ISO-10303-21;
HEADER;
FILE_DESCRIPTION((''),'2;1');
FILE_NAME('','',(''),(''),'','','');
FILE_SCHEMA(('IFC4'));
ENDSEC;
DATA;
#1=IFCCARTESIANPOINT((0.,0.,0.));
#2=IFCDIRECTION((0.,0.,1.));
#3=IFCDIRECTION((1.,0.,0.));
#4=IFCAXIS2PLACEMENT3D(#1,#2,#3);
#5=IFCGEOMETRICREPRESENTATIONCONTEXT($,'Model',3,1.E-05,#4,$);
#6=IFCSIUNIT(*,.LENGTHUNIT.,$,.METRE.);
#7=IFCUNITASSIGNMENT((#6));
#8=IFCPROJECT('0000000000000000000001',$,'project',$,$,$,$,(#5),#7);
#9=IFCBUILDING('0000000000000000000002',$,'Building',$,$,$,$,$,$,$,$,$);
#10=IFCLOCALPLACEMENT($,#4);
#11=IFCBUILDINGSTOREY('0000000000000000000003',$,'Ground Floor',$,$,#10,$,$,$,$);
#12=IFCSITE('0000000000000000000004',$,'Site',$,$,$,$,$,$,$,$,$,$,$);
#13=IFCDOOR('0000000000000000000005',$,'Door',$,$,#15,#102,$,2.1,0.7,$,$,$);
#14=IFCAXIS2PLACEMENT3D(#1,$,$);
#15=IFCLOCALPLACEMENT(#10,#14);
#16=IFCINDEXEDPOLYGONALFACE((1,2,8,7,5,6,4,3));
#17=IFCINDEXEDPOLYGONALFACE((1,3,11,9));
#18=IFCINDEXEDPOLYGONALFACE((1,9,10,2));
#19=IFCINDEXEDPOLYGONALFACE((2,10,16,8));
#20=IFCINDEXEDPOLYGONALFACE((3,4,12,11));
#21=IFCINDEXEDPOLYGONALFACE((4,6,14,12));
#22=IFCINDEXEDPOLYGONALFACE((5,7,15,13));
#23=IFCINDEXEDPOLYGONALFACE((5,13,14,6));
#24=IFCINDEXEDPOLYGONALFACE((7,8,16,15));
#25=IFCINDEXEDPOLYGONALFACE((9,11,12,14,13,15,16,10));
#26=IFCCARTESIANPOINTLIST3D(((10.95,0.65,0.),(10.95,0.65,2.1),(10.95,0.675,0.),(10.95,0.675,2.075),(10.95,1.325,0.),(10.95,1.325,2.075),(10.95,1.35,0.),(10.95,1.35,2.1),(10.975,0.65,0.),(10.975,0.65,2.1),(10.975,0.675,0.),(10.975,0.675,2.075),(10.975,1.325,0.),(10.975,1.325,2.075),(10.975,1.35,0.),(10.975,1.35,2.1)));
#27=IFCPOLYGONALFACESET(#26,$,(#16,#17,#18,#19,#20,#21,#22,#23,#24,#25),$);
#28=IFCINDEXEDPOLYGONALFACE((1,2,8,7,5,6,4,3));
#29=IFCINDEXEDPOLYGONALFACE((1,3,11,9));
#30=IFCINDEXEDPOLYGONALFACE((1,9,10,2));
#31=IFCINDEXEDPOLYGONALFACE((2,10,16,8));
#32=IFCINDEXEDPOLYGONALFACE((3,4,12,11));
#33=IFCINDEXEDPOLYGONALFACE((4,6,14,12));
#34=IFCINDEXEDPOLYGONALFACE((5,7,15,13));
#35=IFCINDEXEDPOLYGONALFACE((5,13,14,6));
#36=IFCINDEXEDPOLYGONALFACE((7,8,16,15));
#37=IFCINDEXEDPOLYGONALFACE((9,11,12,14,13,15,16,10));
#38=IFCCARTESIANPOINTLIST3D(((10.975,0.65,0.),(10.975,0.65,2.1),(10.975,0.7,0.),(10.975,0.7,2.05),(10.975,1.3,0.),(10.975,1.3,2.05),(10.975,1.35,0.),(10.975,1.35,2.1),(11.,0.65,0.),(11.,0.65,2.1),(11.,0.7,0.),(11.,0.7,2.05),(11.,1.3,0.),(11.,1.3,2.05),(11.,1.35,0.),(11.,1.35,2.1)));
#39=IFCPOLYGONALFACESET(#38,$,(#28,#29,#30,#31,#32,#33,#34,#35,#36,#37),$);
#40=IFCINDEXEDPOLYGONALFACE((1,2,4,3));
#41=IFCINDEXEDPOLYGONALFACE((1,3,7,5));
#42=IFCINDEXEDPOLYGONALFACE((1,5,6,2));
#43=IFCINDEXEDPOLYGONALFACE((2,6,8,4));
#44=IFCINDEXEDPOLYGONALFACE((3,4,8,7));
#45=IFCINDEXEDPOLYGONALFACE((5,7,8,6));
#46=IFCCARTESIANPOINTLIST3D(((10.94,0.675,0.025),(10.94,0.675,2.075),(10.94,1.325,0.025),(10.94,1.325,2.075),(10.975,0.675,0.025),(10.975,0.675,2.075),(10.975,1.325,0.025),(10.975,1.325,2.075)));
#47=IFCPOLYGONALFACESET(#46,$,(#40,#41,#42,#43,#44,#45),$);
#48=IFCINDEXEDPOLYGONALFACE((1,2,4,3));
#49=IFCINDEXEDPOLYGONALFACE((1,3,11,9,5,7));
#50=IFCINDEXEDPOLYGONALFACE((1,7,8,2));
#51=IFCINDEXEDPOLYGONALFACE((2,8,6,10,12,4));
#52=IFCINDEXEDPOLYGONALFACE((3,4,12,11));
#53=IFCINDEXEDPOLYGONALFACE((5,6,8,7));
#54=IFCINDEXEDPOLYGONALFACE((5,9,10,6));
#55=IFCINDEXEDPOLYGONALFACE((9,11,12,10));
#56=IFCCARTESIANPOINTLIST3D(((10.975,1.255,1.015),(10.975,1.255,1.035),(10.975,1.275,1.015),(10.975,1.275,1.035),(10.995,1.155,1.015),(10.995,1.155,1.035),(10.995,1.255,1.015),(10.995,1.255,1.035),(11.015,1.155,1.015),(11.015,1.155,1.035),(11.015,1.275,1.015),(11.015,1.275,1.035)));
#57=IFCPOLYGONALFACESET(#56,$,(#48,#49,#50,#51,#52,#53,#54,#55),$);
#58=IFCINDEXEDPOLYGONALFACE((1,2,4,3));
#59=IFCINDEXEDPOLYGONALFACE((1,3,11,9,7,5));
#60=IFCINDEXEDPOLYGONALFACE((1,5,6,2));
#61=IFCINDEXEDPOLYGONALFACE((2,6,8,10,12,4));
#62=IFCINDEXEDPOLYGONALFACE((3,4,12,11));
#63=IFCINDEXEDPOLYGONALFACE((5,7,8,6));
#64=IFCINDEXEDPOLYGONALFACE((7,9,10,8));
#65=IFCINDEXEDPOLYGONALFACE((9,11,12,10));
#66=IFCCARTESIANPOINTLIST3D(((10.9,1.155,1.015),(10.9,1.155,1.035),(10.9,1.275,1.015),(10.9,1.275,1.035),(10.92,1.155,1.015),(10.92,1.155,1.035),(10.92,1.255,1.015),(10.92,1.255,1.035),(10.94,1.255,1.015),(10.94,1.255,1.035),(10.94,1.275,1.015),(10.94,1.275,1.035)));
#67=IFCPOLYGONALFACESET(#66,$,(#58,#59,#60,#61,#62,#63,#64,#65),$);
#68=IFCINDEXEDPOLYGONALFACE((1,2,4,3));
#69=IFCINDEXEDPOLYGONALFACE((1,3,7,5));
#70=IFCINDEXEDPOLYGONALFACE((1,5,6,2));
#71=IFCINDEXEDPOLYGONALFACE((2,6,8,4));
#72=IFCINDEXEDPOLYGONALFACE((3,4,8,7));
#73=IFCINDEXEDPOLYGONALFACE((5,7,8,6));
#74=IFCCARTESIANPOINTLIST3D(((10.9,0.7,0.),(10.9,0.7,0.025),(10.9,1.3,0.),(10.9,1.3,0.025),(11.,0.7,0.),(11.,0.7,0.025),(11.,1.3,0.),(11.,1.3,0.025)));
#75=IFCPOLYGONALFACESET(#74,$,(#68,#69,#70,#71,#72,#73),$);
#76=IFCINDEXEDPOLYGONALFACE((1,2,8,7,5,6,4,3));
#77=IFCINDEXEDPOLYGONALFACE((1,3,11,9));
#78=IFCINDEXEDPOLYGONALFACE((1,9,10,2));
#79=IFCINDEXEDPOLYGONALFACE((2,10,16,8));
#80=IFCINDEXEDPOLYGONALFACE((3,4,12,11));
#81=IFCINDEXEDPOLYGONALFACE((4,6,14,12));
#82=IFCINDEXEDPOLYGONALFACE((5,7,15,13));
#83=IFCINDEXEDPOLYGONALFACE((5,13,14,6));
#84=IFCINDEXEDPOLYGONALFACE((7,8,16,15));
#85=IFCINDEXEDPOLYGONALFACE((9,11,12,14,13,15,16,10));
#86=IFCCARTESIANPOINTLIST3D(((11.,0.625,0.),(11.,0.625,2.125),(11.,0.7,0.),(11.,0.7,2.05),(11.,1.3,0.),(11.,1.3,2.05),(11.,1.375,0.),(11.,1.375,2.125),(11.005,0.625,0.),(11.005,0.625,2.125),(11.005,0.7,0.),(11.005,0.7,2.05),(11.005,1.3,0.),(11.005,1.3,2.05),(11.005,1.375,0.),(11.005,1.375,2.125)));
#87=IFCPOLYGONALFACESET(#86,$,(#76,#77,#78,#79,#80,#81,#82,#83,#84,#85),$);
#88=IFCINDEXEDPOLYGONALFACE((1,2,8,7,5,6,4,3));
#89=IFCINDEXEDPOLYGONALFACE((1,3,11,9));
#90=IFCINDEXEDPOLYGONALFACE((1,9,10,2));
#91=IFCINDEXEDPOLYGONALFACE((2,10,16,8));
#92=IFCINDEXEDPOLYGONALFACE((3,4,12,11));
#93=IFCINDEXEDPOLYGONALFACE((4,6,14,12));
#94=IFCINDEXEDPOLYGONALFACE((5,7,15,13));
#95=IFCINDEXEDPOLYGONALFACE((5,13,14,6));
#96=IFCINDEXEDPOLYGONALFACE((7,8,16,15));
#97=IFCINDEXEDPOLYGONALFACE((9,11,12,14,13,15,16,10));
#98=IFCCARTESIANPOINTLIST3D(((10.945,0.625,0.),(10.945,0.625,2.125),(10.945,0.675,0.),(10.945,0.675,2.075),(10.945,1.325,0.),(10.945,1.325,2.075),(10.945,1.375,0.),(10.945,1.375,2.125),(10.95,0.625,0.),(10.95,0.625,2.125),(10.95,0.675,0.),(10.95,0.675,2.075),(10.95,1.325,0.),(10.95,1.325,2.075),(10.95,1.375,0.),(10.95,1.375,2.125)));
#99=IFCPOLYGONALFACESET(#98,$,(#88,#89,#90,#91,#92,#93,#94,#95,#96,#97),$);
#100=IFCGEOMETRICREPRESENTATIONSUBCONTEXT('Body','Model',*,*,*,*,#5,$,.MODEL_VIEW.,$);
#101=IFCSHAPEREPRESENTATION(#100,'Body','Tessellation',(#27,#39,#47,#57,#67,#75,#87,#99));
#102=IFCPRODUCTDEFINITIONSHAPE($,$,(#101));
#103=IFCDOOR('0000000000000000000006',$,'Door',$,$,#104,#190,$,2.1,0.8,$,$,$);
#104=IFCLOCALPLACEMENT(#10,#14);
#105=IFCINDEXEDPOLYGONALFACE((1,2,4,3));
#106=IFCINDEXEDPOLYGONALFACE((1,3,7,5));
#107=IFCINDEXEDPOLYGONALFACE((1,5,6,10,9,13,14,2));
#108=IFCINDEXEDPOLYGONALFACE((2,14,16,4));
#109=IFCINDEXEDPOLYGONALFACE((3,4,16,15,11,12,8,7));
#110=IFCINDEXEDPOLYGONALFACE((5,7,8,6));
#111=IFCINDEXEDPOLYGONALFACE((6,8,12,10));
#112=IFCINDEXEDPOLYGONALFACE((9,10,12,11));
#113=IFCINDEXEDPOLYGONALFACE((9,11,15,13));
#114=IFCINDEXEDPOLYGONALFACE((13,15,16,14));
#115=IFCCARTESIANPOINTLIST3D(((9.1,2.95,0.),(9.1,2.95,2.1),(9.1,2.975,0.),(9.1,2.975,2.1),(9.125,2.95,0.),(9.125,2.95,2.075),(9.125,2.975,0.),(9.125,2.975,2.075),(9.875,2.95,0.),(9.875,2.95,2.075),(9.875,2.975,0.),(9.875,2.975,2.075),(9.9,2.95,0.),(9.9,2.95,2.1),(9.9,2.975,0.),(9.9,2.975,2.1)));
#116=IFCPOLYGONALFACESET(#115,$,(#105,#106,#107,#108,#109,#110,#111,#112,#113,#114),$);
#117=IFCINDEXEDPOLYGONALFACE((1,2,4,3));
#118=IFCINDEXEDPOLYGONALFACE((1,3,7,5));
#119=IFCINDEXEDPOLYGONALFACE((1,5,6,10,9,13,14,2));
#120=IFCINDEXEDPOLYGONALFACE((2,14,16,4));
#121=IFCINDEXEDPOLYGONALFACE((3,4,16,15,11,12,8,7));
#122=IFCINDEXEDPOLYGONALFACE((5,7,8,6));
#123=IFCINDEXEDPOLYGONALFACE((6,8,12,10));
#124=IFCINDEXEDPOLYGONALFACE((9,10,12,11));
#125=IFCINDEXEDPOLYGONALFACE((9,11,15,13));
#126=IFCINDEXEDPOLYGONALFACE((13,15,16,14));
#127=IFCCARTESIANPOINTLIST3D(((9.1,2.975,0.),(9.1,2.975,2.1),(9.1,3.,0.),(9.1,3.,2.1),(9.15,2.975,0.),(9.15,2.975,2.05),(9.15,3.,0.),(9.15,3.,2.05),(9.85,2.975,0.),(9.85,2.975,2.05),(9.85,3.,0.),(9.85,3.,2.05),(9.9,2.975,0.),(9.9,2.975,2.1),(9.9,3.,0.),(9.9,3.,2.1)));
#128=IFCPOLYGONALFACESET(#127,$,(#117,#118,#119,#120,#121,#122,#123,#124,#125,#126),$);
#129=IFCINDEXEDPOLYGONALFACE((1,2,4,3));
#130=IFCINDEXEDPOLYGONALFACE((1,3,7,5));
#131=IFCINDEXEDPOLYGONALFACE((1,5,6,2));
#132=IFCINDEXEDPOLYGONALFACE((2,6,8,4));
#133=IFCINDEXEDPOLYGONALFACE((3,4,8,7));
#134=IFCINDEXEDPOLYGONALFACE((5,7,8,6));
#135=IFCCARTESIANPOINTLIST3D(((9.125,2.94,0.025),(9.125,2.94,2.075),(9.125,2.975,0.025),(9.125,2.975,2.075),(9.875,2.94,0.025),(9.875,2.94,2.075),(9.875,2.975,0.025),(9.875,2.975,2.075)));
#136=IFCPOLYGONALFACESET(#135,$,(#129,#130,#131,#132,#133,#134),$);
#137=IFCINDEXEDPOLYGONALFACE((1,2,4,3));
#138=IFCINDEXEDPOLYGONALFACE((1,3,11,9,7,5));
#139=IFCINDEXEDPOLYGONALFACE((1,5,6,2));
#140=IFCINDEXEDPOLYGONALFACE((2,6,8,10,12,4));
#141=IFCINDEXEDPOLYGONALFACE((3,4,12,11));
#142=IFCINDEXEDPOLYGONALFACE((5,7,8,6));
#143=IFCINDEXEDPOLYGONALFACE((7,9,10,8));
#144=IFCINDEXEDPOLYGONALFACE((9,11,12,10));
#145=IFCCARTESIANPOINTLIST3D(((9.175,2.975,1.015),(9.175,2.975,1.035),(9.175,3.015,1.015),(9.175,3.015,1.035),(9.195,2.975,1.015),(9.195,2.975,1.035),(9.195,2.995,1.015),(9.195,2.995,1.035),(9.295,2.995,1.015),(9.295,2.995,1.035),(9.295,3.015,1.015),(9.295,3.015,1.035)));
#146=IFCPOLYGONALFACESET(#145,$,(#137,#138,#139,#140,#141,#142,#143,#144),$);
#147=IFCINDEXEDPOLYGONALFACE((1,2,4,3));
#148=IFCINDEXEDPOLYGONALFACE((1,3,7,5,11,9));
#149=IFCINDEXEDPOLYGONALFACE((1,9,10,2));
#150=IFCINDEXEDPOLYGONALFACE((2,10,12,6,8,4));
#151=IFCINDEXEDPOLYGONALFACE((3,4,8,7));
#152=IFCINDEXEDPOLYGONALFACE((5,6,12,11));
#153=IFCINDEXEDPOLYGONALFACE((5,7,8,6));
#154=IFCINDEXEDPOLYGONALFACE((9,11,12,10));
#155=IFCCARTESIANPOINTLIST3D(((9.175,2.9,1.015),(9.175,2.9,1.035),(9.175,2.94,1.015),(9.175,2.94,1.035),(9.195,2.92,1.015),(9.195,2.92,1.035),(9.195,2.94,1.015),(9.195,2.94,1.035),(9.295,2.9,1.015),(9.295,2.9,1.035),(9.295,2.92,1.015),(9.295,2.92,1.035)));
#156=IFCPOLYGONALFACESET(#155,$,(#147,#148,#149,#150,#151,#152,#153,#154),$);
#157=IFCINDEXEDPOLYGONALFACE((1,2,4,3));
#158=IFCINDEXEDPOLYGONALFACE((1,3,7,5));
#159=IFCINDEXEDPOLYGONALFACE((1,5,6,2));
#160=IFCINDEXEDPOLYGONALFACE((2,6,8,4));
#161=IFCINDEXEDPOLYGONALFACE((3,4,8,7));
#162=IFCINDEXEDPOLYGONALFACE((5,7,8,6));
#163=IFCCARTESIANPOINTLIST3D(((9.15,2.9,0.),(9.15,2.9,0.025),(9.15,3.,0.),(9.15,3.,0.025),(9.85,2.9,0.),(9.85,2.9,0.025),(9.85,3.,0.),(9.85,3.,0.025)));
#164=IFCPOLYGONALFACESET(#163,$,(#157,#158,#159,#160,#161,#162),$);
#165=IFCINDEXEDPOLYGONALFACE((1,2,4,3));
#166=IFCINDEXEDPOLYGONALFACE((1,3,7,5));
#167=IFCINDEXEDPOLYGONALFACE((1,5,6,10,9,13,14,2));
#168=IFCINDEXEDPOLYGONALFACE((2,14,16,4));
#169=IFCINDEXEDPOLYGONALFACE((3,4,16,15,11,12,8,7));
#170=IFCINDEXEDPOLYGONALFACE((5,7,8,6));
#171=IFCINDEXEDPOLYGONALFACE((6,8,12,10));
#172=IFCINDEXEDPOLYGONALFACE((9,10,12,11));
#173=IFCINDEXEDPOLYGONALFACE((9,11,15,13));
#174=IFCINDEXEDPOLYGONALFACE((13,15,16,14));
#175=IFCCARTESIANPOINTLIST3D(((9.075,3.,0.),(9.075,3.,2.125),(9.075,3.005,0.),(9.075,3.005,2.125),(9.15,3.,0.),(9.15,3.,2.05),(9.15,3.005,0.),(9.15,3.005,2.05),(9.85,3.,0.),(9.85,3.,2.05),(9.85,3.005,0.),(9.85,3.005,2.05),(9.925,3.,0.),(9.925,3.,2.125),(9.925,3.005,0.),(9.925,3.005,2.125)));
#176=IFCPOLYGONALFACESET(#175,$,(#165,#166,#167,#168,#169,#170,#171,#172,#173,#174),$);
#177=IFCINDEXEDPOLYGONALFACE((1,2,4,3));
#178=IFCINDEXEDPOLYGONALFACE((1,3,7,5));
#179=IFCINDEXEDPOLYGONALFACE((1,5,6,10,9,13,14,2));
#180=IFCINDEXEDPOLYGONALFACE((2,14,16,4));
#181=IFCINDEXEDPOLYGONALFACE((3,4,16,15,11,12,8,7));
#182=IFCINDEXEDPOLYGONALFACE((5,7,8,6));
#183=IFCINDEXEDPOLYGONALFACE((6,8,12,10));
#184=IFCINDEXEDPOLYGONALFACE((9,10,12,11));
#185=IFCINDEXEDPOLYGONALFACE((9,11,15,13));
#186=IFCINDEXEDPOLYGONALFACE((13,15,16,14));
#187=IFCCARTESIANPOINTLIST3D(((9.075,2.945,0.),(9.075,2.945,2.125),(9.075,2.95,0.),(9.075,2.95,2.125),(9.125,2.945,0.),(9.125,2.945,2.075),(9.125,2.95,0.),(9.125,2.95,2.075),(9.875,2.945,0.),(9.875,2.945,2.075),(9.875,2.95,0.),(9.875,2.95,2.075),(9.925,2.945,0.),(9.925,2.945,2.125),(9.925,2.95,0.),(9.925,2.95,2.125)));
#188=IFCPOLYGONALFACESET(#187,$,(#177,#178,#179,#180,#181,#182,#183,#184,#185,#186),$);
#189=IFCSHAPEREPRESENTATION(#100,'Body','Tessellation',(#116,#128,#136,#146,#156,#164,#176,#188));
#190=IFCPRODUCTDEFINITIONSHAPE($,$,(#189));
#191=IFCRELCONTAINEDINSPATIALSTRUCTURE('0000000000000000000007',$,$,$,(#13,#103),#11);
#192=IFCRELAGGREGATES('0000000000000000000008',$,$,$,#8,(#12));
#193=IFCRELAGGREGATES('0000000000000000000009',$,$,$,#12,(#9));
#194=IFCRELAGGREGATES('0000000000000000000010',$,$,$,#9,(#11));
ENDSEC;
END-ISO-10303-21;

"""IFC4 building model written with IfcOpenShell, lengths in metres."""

from ifc_helpers import new_model, si_unit, frame, origin_with_axes, place, context, subcontext, project, spatial, line, indexed_curve, outline, extrude, element, save


model = new_model("IFC4")

# Units and contexts
model_context = context("Model", 3, precision=1e-05, world=origin_with_axes())
body_context = subcontext(model_context, "Body", "Model", "MODEL_VIEW")
ifc_project = project(units=[si_unit("LENGTHUNIT", "METRE")], contexts=[model_context])

# Site, building, storey
site = spatial("IfcSite", under=ifc_project, Name="Site")
building = spatial("IfcBuilding", under=site, Name="Building")
storey_placement = place(None, origin_with_axes())
storey = spatial("IfcBuildingStorey", under=building, at=storey_placement, Name="Ground Floor")

# Doors
door_1_placement = place(storey_placement, frame((11.0, 0.65, 0.0), z_axis=(0.0, 0.0, 1.0), x_axis=(0.0, 1.0, 0.0)))
element("IfcDoor", 1, at=door_1_placement, inside=storey, Name="Door", OverallHeight=2.1, OverallWidth=0.7, context=body_context, shape_type="SweptSolid", body=[
    extrude(outline(indexed_curve([(0.0, 0.0), (0.0, 2.1), (0.7, 2.1), (0.7, 0.0), (0.675, 0.0), (0.675, 2.075), (0.025, 2.075), (0.025, 0.0)], segments=[line(1, 2, 3, 4, 5, 6, 7, 8, 1)])), frame((0.0, 0.025, 0.0), z_axis=(0.0, -1.0, 0.0), x_axis=(1.0, 0.0, 0.0)), (0.0, 0.0, -1.0), 0.025),
    extrude(outline(indexed_curve([(0.0, 0.0), (0.0, 2.1), (0.7, 2.1), (0.7, 0.0), (0.65, 0.0), (0.65, 2.05), (0.05, 2.05), (0.05, 0.0)], segments=[line(1, 2, 3, 4, 5, 6, 7, 8, 1)])), frame((0.0, 0.0, 0.0), z_axis=(0.0, -1.0, 0.0), x_axis=(1.0, 0.0, 0.0)), (0.0, 0.0, -1.0), 0.025),
    extrude(outline(indexed_curve([(0.0, 0.0), (0.65, 0.0), (0.65, 0.035), (0.0, 0.035)], segments=[line(1, 2, 3, 4, 1)])), frame((0.025, 0.025, 0.025), z_axis=(0.0, 0.0, 1.0), x_axis=(1.0, 0.0, 0.0)), (0.0, 0.0, 1.0), 2.05),
    extrude(outline(indexed_curve([(0.0, 0.0), (0.0, -0.04), (-0.12, -0.04), (-0.12, -0.02), (-0.02, -0.02), (-0.02, 0.0)], segments=[line(1, 2, 3, 4, 5, 6, 1)])), frame((0.625, 0.025, 1.015), z_axis=(0.0, 0.0, 1.0), x_axis=(1.0, 0.0, 0.0)), (0.0, 0.0, 1.0), 0.02),
    extrude(outline(indexed_curve([(0.0, 0.0), (0.0, 0.04), (-0.12, 0.04), (-0.12, 0.02), (-0.02, 0.02), (-0.02, 0.0)], segments=[line(1, 2, 3, 4, 5, 6, 1)])), frame((0.625, 0.06, 1.015), z_axis=(0.0, 0.0, 1.0), x_axis=(1.0, 0.0, 0.0)), (0.0, 0.0, 1.0), 0.02),
    extrude(outline(indexed_curve([(0.0, 0.0), (0.6, 0.0), (0.6, 0.1), (0.0, 0.1)], segments=[line(1, 2, 3, 4, 1)])), frame((0.05, 0.0, 0.0), z_axis=(0.0, 0.0, 1.0), x_axis=(1.0, 0.0, 0.0)), (0.0, 0.0, 1.0), 0.025),
    extrude(outline(indexed_curve([(0.0, 0.0), (0.0, 2.125), (0.75, 2.125), (0.75, 0.0), (0.675, 0.0), (0.675, 2.05), (0.075, 2.05), (0.075, 0.0)], segments=[line(1, 2, 3, 4, 5, 6, 7, 8, 1)])), frame((-0.025, -0.005, 0.0), z_axis=(0.0, -1.0, 0.0), x_axis=(1.0, 0.0, 0.0)), (0.0, 0.0, -1.0), 0.005),
    extrude(outline(indexed_curve([(0.0, 0.0), (0.0, 2.125), (0.75, 2.125), (0.75, 0.0), (0.7, 0.0), (0.7, 2.075), (0.05, 2.075), (0.05, 0.0)], segments=[line(1, 2, 3, 4, 5, 6, 7, 8, 1)])), frame((-0.025, 0.05, 0.0), z_axis=(0.0, -1.0, 0.0), x_axis=(1.0, 0.0, 0.0)), (0.0, 0.0, -1.0), 0.005),
])
door_2_placement = place(storey_placement, frame((9.9, 3.0, 0.0), z_axis=(0.0, 0.0, 1.0), x_axis=(-1.0, 0.0, 0.0)))
element("IfcDoor", 2, at=door_2_placement, inside=storey, Name="Door", OverallHeight=2.1, OverallWidth=0.8, context=body_context, shape_type="SweptSolid", body=[
    extrude(outline(indexed_curve([(0.0, 0.0), (0.0, 2.1), (0.8, 2.1), (0.8, 0.0), (0.775, 0.0), (0.775, 2.075), (0.025, 2.075), (0.025, 0.0)], segments=[line(1, 2, 3, 4, 5, 6, 7, 8, 1)])), frame((0.0, 0.025, 0.0), z_axis=(0.0, -1.0, 0.0), x_axis=(1.0, 0.0, 0.0)), (0.0, 0.0, -1.0), 0.025),
    extrude(outline(indexed_curve([(0.0, 0.0), (0.0, 2.1), (0.8, 2.1), (0.8, 0.0), (0.75, 0.0), (0.75, 2.05), (0.05, 2.05), (0.05, 0.0)], segments=[line(1, 2, 3, 4, 5, 6, 7, 8, 1)])), frame((0.0, 0.0, 0.0), z_axis=(0.0, -1.0, 0.0), x_axis=(1.0, 0.0, 0.0)), (0.0, 0.0, -1.0), 0.025),
    extrude(outline(indexed_curve([(0.0, 0.0), (0.75, 0.0), (0.75, 0.035), (0.0, 0.035)], segments=[line(1, 2, 3, 4, 1)])), frame((0.025, 0.025, 0.025), z_axis=(0.0, 0.0, 1.0), x_axis=(1.0, 0.0, 0.0)), (0.0, 0.0, 1.0), 2.05),
    extrude(outline(indexed_curve([(0.0, 0.0), (0.0, -0.04), (-0.12, -0.04), (-0.12, -0.02), (-0.02, -0.02), (-0.02, 0.0)], segments=[line(1, 2, 3, 4, 5, 6, 1)])), frame((0.725, 0.025, 1.015), z_axis=(0.0, 0.0, 1.0), x_axis=(1.0, 0.0, 0.0)), (0.0, 0.0, 1.0), 0.02),
    extrude(outline(indexed_curve([(0.0, 0.0), (0.0, 0.04), (-0.12, 0.04), (-0.12, 0.02), (-0.02, 0.02), (-0.02, 0.0)], segments=[line(1, 2, 3, 4, 5, 6, 1)])), frame((0.725, 0.06, 1.015), z_axis=(0.0, 0.0, 1.0), x_axis=(1.0, 0.0, 0.0)), (0.0, 0.0, 1.0), 0.02),
    extrude(outline(indexed_curve([(0.0, 0.0), (0.7, 0.0), (0.7, 0.1), (0.0, 0.1)], segments=[line(1, 2, 3, 4, 1)])), frame((0.05, 0.0, 0.0), z_axis=(0.0, 0.0, 1.0), x_axis=(1.0, 0.0, 0.0)), (0.0, 0.0, 1.0), 0.025),
    extrude(outline(indexed_curve([(0.0, 0.0), (0.0, 2.125), (0.85, 2.125), (0.85, 0.0), (0.775, 0.0), (0.775, 2.05), (0.075, 2.05), (0.075, 0.0)], segments=[line(1, 2, 3, 4, 5, 6, 7, 8, 1)])), frame((-0.025, -0.005, 0.0), z_axis=(0.0, -1.0, 0.0), x_axis=(1.0, 0.0, 0.0)), (0.0, 0.0, -1.0), 0.005),
    extrude(outline(indexed_curve([(0.0, 0.0), (0.0, 2.125), (0.85, 2.125), (0.85, 0.0), (0.8, 0.0), (0.8, 2.075), (0.05, 2.075), (0.05, 0.0)], segments=[line(1, 2, 3, 4, 5, 6, 7, 8, 1)])), frame((-0.025, 0.05, 0.0), z_axis=(0.0, -1.0, 0.0), x_axis=(1.0, 0.0, 0.0)), (0.0, 0.0, -1.0), 0.005),
])

save(model, "model.ifc")
